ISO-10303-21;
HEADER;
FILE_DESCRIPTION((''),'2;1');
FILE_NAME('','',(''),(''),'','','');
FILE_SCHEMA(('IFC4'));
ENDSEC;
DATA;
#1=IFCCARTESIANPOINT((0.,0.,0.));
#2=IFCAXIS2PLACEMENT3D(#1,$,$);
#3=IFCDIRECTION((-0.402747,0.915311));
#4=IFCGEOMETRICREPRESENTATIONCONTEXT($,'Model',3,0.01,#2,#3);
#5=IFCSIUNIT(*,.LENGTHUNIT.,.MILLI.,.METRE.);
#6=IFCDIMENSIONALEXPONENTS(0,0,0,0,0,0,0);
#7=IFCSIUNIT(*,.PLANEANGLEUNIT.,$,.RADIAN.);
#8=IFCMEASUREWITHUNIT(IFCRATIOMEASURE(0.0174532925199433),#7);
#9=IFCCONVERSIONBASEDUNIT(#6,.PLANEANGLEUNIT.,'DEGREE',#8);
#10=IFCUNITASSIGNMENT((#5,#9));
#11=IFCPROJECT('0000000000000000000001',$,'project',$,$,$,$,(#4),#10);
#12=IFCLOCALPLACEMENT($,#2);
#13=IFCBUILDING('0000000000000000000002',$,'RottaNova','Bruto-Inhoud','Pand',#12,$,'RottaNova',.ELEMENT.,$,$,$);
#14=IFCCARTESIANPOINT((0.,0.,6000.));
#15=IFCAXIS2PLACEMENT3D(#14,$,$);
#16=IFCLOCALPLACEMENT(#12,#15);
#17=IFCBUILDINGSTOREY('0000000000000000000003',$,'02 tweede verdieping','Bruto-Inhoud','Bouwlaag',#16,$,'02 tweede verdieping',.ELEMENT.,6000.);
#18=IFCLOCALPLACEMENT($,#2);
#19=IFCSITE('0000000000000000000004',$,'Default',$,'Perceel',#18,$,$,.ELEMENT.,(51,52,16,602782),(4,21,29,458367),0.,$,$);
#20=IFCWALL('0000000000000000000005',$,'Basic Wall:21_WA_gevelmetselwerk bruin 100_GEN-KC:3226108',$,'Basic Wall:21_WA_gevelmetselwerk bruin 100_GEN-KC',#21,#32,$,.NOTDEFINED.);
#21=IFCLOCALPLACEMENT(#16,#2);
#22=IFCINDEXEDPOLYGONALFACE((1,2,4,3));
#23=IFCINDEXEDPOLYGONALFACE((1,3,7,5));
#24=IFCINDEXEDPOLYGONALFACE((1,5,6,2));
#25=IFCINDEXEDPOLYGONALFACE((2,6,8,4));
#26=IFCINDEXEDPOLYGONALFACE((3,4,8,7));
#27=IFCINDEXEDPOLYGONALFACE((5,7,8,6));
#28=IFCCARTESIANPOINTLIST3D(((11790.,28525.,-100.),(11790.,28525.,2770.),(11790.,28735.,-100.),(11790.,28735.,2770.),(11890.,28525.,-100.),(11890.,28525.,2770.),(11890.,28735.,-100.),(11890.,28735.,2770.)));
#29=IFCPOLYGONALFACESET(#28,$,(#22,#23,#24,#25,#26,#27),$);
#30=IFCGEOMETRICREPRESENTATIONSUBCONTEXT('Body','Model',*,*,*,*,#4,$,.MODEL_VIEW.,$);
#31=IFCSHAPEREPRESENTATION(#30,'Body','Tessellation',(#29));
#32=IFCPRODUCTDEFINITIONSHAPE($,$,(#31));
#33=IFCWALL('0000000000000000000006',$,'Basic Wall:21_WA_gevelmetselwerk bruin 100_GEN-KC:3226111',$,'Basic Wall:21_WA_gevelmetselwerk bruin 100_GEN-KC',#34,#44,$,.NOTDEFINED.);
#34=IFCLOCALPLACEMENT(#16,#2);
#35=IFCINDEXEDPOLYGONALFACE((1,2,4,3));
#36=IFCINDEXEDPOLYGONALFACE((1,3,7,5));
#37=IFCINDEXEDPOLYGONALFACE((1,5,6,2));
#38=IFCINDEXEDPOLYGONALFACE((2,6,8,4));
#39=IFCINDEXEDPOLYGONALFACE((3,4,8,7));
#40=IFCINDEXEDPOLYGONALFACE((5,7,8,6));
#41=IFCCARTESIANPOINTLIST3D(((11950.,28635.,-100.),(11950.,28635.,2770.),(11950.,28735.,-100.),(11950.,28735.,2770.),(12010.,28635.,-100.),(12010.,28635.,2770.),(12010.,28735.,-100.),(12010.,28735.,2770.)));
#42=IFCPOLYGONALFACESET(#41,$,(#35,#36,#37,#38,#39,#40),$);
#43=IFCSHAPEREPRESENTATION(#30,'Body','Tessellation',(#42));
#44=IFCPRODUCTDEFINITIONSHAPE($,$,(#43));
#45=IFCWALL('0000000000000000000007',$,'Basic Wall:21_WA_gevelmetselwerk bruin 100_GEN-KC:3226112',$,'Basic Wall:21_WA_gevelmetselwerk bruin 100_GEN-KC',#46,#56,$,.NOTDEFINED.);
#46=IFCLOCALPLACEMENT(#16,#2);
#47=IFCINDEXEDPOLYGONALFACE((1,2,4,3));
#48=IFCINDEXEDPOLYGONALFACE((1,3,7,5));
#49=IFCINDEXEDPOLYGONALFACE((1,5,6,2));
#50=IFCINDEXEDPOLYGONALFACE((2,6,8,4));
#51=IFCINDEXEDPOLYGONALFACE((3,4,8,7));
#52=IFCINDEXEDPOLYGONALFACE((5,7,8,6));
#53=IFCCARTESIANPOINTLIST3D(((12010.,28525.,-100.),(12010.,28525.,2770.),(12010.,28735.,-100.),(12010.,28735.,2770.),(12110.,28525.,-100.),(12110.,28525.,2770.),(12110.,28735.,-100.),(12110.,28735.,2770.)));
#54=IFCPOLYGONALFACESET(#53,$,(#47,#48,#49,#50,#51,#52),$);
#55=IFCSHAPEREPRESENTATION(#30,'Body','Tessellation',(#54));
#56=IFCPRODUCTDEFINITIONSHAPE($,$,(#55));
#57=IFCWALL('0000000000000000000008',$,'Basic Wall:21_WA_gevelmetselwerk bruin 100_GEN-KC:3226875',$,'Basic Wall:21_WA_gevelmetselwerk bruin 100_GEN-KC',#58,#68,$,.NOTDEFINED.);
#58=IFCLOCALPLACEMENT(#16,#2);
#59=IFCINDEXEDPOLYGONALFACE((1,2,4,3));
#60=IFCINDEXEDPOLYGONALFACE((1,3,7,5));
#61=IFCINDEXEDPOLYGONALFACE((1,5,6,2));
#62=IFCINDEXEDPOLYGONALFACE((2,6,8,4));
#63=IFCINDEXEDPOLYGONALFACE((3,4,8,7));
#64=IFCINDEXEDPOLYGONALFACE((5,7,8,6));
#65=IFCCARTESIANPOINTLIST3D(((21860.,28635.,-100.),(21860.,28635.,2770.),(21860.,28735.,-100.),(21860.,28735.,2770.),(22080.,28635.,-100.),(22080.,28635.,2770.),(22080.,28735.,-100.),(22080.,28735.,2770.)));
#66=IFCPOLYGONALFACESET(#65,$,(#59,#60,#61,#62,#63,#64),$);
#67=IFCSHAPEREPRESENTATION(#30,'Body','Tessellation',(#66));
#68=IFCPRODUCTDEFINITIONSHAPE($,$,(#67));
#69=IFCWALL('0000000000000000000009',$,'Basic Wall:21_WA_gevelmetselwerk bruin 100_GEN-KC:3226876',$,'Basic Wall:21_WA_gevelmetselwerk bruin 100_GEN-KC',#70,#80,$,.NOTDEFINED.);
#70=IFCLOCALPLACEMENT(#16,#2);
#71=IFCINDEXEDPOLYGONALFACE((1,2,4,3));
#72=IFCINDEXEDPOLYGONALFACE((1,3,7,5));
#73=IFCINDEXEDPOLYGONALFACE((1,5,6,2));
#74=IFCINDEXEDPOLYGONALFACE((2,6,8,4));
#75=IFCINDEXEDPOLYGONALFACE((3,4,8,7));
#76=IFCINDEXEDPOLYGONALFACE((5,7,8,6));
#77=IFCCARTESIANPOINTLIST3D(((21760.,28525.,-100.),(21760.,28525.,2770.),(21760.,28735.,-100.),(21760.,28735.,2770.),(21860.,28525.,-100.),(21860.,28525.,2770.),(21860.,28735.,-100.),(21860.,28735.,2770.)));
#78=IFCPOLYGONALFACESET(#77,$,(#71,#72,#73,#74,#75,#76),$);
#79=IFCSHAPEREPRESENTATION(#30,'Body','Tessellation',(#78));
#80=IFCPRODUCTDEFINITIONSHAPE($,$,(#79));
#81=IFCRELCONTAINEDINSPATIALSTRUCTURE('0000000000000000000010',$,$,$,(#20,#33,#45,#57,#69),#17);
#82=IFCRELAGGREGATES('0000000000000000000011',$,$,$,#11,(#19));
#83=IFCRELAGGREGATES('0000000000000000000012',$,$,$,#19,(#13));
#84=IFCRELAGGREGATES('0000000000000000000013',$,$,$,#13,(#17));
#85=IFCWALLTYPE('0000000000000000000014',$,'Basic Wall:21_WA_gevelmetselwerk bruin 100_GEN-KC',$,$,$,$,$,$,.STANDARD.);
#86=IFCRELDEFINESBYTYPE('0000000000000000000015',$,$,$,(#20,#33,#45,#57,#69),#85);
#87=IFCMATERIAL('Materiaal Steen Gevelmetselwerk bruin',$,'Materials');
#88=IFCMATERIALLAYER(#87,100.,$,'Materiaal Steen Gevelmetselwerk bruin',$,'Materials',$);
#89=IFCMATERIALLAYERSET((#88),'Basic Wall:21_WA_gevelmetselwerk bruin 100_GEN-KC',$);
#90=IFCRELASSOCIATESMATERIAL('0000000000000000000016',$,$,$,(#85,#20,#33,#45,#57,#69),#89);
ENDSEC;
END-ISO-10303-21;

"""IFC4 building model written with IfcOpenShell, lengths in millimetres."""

from ifc_helpers import new_model, entity, si_unit, converted_unit, direction, frame, frame_2d, origin, place, context, subcontext, project, spatial, rectangle, extrude, material, layer, layer_set, type_object, element, save


model = new_model("IFC4")

# Units and contexts
model_context = context("Model", 3, precision=0.01, world=origin(), true_north=direction((-0.402747, 0.915311)))
body_context = subcontext(model_context, "Body", "Model", "MODEL_VIEW")
ifc_project = project(units=[si_unit("LENGTHUNIT", "METRE", prefix="MILLI"), converted_unit("PLANEANGLEUNIT", "DEGREE", entity("IfcRatioMeasure", 0.0174532925199433), si_unit("PLANEANGLEUNIT", "RADIAN"), dimensions=[0, 0, 0, 0, 0, 0, 0])], contexts=[model_context])

# Site, building, storey
site_placement = place(None, origin())
site = spatial("IfcSite", under=ifc_project, at=site_placement, Name="Default", ObjectType="Perceel", CompositionType="ELEMENT", RefLatitude=(51, 52, 16, 602782), RefLongitude=(4, 21, 29, 458367), RefElevation=0.0)
building_placement = place(None, origin())
building = spatial("IfcBuilding", under=site, at=building_placement, Name="RottaNova", Description="Bruto-Inhoud", ObjectType="Pand", LongName="RottaNova", CompositionType="ELEMENT")
storey_placement = place(building_placement, frame((0.0, 0.0, 6000.0)))
storey = spatial("IfcBuildingStorey", under=building, at=storey_placement, Name="02 tweede verdieping", Description="Bruto-Inhoud", ObjectType="Bouwlaag", LongName="02 tweede verdieping", CompositionType="ELEMENT", Elevation=6000.0)

# Walls
ifc_material_1 = material(Name="Materiaal Steen Gevelmetselwerk bruin", Category="Materials")
ifc_layer_1 = layer(ifc_material_1, 100.0, Name="Materiaal Steen Gevelmetselwerk bruin", Category="Materials")
ifc_layer_set_1 = layer_set([ifc_layer_1], Name="Basic Wall:21_WA_gevelmetselwerk bruin 100_GEN-KC")
wall_type_1 = type_object("IfcWallType", Name="Basic Wall:21_WA_gevelmetselwerk bruin 100_GEN-KC", PredefinedType="STANDARD", material=ifc_layer_set_1)
wall_1_placement = place(storey_placement, frame((11840.0, 28735.0, -100.0), z_axis=(0.0, 0.0, 1.0), x_axis=(0.0, -1.0, 0.0)))
element("IfcWall", 1, at=wall_1_placement, inside=storey, type_object=wall_type_1, material=ifc_layer_set_1, Name="Basic Wall:21_WA_gevelmetselwerk bruin 100_GEN-KC:3226108", ObjectType="Basic Wall:21_WA_gevelmetselwerk bruin 100_GEN-KC", PredefinedType="NOTDEFINED", context=body_context, shape_type="SweptSolid", body=[
    extrude(rectangle(XDim=210.0, YDim=100.0, at=frame_2d((105.0, 0.0), x_axis=(-1.0, 0.0))), origin(), (0.0, 0.0, 1.0), 2870.0),
])
wall_2_placement = place(storey_placement, frame((12010.0, 28685.0, -100.0), z_axis=(0.0, 0.0, 1.0), x_axis=(-1.0, 0.0, 0.0)))
element("IfcWall", 2, at=wall_2_placement, inside=storey, type_object=wall_type_1, material=ifc_layer_set_1, Name="Basic Wall:21_WA_gevelmetselwerk bruin 100_GEN-KC:3226111", ObjectType="Basic Wall:21_WA_gevelmetselwerk bruin 100_GEN-KC", PredefinedType="NOTDEFINED", context=body_context, shape_type="SweptSolid", body=[
    extrude(rectangle(XDim=60.0, YDim=100.0, at=frame_2d((30.0, 0.0), x_axis=(-1.0, 0.0))), origin(), (0.0, 0.0, 1.0), 2870.0),
])
wall_3_placement = place(storey_placement, frame((12060.0, 28735.0, -100.0), z_axis=(0.0, 0.0, 1.0), x_axis=(0.0, -1.0, 0.0)))
element("IfcWall", 3, at=wall_3_placement, inside=storey, type_object=wall_type_1, material=ifc_layer_set_1, Name="Basic Wall:21_WA_gevelmetselwerk bruin 100_GEN-KC:3226112", ObjectType="Basic Wall:21_WA_gevelmetselwerk bruin 100_GEN-KC", PredefinedType="NOTDEFINED", context=body_context, shape_type="SweptSolid", body=[
    extrude(rectangle(XDim=210.0, YDim=100.0, at=frame_2d((105.0, 0.0), x_axis=(-1.0, 0.0))), origin(), (0.0, 0.0, 1.0), 2870.0),
])
wall_4_placement = place(storey_placement, frame((21860.0, 28685.0, -100.0)))
element("IfcWall", 4, at=wall_4_placement, inside=storey, type_object=wall_type_1, material=ifc_layer_set_1, Name="Basic Wall:21_WA_gevelmetselwerk bruin 100_GEN-KC:3226875", ObjectType="Basic Wall:21_WA_gevelmetselwerk bruin 100_GEN-KC", PredefinedType="NOTDEFINED", context=body_context, shape_type="SweptSolid", body=[
    extrude(rectangle(XDim=220.0, YDim=100.0, at=frame_2d((110.0, 0.0), x_axis=(-1.0, 0.0))), origin(), (0.0, 0.0, 1.0), 2870.0),
])
wall_5_placement = place(storey_placement, frame((21810.0, 28735.0, -100.0), z_axis=(0.0, 0.0, 1.0), x_axis=(0.0, -1.0, 0.0)))
element("IfcWall", 5, at=wall_5_placement, inside=storey, type_object=wall_type_1, material=ifc_layer_set_1, Name="Basic Wall:21_WA_gevelmetselwerk bruin 100_GEN-KC:3226876", ObjectType="Basic Wall:21_WA_gevelmetselwerk bruin 100_GEN-KC", PredefinedType="NOTDEFINED", context=body_context, shape_type="SweptSolid", body=[
    extrude(rectangle(XDim=210.0, YDim=100.0, at=frame_2d((105.0, 0.0), x_axis=(-1.0, 0.0))), origin(), (0.0, 0.0, 1.0), 2870.0),
])

save(model, "model.ifc")
